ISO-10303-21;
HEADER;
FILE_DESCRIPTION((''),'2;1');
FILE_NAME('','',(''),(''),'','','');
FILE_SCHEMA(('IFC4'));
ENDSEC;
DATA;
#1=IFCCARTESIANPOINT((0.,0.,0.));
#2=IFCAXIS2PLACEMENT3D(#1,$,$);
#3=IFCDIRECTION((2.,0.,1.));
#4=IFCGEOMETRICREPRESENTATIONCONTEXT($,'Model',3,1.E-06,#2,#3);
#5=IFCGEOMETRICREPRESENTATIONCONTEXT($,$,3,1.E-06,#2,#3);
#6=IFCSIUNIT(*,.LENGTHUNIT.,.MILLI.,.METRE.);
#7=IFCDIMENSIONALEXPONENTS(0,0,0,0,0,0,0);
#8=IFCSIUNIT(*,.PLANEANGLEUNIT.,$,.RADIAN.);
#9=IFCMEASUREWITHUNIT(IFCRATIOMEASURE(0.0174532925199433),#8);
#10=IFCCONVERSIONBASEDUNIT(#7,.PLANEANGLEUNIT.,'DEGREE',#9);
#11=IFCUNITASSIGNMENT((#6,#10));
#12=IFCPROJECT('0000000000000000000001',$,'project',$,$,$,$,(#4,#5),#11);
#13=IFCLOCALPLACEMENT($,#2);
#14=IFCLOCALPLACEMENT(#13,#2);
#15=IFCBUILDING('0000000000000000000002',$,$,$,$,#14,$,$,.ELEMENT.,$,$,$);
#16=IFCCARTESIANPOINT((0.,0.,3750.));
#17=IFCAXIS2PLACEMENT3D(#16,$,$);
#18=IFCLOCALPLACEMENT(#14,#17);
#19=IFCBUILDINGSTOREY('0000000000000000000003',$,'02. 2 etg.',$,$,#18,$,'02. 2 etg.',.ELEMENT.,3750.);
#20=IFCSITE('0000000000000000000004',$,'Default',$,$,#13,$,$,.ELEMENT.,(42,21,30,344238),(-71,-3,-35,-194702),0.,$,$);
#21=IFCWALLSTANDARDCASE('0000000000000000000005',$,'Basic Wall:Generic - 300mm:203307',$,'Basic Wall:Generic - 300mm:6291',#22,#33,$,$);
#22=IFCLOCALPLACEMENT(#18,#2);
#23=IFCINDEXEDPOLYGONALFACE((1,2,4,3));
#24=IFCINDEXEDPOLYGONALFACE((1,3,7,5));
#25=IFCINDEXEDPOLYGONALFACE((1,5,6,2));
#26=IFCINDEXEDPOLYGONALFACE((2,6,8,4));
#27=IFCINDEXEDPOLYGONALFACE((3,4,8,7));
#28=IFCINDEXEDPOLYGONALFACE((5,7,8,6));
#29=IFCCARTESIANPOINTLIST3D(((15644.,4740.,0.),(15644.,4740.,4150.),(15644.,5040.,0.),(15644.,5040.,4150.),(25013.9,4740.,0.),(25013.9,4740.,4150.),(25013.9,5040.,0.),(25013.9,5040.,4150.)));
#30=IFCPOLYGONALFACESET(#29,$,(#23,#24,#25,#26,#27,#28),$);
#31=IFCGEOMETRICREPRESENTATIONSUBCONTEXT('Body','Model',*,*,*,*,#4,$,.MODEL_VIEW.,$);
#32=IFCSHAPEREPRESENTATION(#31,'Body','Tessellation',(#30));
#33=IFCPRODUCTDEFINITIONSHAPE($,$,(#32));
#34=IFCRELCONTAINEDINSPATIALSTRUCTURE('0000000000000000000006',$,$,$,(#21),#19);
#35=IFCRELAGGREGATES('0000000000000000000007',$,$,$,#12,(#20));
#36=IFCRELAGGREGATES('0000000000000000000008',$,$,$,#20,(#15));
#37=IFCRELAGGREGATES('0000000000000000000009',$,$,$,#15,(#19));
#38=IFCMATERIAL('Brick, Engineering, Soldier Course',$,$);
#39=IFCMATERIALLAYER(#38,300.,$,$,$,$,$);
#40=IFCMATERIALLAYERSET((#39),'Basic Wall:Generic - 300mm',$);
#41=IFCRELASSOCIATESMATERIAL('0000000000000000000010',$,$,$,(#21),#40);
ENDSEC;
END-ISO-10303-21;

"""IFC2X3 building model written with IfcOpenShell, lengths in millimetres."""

from ifc_helpers import new_model, entity, si_unit, converted_unit, direction, frame, frame_2d, origin, place, context, subcontext, project, spatial, rectangle, extrude, material, layer, layer_set, layer_usage, element, save


model = new_model("IFC2X3")

# Units and contexts
model_context = context("Model", 3, precision=1e-06, world=origin(), true_north=direction((2.0, 0.0, 1.0)))
context_of_model = context(None, 3, precision=1e-06, world=origin(), true_north=direction((2.0, 0.0, 1.0)))
body_context = subcontext(model_context, "Body", "Model", "MODEL_VIEW")
ifc_project = project(units=[si_unit("LENGTHUNIT", "METRE", prefix="MILLI"), converted_unit("PLANEANGLEUNIT", "DEGREE", entity("IfcRatioMeasure", 0.0174532925199433), si_unit("PLANEANGLEUNIT", "RADIAN"), dimensions=[0, 0, 0, 0, 0, 0, 0])], contexts=[model_context, context_of_model])

# Site, building, storey
site_placement = place(None, origin())
site = spatial("IfcSite", under=ifc_project, at=site_placement, Name="Default", CompositionType="ELEMENT", RefLatitude=(42, 21, 30, 344238), RefLongitude=(-71, -3, -35, -194702), RefElevation=0.0)
building_placement = place(site_placement, origin())
building = spatial("IfcBuilding", under=site, at=building_placement, CompositionType="ELEMENT")
storey_placement = place(building_placement, frame((0.0, 0.0, 3750.0)))
storey = spatial("IfcBuildingStorey", under=building, at=storey_placement, Name="02. 2 etg.", LongName="02. 2 etg.", CompositionType="ELEMENT", Elevation=3750.0)

# Wall
ifc_material_1 = material(Name="Brick, Engineering, Soldier Course")
ifc_layer_1 = layer(ifc_material_1, 300.0)
ifc_layer_set_1 = layer_set([ifc_layer_1], Name="Basic Wall:Generic - 300mm")
ifc_layer_usage_1 = layer_usage(ifc_layer_set_1, "AXIS2", "NEGATIVE", 150.0)
wall_1_placement = place(storey_placement, frame((15644.0, 4890.0, 0.0)))
element("IfcWallStandardCase", 1, at=wall_1_placement, inside=storey, material=ifc_layer_usage_1, Name="Basic Wall:Generic - 300mm:203307", ObjectType="Basic Wall:Generic - 300mm:6291", context=body_context, shape_type="SweptSolid", body=[
    extrude(rectangle(XDim=9369.9, YDim=300.0, at=frame_2d((4684.9, 0.0), x_axis=(-1.0, 0.0))), origin(), (0.0, 0.0, 1.0), 4150.0),
])

save(model, "model.ifc")
